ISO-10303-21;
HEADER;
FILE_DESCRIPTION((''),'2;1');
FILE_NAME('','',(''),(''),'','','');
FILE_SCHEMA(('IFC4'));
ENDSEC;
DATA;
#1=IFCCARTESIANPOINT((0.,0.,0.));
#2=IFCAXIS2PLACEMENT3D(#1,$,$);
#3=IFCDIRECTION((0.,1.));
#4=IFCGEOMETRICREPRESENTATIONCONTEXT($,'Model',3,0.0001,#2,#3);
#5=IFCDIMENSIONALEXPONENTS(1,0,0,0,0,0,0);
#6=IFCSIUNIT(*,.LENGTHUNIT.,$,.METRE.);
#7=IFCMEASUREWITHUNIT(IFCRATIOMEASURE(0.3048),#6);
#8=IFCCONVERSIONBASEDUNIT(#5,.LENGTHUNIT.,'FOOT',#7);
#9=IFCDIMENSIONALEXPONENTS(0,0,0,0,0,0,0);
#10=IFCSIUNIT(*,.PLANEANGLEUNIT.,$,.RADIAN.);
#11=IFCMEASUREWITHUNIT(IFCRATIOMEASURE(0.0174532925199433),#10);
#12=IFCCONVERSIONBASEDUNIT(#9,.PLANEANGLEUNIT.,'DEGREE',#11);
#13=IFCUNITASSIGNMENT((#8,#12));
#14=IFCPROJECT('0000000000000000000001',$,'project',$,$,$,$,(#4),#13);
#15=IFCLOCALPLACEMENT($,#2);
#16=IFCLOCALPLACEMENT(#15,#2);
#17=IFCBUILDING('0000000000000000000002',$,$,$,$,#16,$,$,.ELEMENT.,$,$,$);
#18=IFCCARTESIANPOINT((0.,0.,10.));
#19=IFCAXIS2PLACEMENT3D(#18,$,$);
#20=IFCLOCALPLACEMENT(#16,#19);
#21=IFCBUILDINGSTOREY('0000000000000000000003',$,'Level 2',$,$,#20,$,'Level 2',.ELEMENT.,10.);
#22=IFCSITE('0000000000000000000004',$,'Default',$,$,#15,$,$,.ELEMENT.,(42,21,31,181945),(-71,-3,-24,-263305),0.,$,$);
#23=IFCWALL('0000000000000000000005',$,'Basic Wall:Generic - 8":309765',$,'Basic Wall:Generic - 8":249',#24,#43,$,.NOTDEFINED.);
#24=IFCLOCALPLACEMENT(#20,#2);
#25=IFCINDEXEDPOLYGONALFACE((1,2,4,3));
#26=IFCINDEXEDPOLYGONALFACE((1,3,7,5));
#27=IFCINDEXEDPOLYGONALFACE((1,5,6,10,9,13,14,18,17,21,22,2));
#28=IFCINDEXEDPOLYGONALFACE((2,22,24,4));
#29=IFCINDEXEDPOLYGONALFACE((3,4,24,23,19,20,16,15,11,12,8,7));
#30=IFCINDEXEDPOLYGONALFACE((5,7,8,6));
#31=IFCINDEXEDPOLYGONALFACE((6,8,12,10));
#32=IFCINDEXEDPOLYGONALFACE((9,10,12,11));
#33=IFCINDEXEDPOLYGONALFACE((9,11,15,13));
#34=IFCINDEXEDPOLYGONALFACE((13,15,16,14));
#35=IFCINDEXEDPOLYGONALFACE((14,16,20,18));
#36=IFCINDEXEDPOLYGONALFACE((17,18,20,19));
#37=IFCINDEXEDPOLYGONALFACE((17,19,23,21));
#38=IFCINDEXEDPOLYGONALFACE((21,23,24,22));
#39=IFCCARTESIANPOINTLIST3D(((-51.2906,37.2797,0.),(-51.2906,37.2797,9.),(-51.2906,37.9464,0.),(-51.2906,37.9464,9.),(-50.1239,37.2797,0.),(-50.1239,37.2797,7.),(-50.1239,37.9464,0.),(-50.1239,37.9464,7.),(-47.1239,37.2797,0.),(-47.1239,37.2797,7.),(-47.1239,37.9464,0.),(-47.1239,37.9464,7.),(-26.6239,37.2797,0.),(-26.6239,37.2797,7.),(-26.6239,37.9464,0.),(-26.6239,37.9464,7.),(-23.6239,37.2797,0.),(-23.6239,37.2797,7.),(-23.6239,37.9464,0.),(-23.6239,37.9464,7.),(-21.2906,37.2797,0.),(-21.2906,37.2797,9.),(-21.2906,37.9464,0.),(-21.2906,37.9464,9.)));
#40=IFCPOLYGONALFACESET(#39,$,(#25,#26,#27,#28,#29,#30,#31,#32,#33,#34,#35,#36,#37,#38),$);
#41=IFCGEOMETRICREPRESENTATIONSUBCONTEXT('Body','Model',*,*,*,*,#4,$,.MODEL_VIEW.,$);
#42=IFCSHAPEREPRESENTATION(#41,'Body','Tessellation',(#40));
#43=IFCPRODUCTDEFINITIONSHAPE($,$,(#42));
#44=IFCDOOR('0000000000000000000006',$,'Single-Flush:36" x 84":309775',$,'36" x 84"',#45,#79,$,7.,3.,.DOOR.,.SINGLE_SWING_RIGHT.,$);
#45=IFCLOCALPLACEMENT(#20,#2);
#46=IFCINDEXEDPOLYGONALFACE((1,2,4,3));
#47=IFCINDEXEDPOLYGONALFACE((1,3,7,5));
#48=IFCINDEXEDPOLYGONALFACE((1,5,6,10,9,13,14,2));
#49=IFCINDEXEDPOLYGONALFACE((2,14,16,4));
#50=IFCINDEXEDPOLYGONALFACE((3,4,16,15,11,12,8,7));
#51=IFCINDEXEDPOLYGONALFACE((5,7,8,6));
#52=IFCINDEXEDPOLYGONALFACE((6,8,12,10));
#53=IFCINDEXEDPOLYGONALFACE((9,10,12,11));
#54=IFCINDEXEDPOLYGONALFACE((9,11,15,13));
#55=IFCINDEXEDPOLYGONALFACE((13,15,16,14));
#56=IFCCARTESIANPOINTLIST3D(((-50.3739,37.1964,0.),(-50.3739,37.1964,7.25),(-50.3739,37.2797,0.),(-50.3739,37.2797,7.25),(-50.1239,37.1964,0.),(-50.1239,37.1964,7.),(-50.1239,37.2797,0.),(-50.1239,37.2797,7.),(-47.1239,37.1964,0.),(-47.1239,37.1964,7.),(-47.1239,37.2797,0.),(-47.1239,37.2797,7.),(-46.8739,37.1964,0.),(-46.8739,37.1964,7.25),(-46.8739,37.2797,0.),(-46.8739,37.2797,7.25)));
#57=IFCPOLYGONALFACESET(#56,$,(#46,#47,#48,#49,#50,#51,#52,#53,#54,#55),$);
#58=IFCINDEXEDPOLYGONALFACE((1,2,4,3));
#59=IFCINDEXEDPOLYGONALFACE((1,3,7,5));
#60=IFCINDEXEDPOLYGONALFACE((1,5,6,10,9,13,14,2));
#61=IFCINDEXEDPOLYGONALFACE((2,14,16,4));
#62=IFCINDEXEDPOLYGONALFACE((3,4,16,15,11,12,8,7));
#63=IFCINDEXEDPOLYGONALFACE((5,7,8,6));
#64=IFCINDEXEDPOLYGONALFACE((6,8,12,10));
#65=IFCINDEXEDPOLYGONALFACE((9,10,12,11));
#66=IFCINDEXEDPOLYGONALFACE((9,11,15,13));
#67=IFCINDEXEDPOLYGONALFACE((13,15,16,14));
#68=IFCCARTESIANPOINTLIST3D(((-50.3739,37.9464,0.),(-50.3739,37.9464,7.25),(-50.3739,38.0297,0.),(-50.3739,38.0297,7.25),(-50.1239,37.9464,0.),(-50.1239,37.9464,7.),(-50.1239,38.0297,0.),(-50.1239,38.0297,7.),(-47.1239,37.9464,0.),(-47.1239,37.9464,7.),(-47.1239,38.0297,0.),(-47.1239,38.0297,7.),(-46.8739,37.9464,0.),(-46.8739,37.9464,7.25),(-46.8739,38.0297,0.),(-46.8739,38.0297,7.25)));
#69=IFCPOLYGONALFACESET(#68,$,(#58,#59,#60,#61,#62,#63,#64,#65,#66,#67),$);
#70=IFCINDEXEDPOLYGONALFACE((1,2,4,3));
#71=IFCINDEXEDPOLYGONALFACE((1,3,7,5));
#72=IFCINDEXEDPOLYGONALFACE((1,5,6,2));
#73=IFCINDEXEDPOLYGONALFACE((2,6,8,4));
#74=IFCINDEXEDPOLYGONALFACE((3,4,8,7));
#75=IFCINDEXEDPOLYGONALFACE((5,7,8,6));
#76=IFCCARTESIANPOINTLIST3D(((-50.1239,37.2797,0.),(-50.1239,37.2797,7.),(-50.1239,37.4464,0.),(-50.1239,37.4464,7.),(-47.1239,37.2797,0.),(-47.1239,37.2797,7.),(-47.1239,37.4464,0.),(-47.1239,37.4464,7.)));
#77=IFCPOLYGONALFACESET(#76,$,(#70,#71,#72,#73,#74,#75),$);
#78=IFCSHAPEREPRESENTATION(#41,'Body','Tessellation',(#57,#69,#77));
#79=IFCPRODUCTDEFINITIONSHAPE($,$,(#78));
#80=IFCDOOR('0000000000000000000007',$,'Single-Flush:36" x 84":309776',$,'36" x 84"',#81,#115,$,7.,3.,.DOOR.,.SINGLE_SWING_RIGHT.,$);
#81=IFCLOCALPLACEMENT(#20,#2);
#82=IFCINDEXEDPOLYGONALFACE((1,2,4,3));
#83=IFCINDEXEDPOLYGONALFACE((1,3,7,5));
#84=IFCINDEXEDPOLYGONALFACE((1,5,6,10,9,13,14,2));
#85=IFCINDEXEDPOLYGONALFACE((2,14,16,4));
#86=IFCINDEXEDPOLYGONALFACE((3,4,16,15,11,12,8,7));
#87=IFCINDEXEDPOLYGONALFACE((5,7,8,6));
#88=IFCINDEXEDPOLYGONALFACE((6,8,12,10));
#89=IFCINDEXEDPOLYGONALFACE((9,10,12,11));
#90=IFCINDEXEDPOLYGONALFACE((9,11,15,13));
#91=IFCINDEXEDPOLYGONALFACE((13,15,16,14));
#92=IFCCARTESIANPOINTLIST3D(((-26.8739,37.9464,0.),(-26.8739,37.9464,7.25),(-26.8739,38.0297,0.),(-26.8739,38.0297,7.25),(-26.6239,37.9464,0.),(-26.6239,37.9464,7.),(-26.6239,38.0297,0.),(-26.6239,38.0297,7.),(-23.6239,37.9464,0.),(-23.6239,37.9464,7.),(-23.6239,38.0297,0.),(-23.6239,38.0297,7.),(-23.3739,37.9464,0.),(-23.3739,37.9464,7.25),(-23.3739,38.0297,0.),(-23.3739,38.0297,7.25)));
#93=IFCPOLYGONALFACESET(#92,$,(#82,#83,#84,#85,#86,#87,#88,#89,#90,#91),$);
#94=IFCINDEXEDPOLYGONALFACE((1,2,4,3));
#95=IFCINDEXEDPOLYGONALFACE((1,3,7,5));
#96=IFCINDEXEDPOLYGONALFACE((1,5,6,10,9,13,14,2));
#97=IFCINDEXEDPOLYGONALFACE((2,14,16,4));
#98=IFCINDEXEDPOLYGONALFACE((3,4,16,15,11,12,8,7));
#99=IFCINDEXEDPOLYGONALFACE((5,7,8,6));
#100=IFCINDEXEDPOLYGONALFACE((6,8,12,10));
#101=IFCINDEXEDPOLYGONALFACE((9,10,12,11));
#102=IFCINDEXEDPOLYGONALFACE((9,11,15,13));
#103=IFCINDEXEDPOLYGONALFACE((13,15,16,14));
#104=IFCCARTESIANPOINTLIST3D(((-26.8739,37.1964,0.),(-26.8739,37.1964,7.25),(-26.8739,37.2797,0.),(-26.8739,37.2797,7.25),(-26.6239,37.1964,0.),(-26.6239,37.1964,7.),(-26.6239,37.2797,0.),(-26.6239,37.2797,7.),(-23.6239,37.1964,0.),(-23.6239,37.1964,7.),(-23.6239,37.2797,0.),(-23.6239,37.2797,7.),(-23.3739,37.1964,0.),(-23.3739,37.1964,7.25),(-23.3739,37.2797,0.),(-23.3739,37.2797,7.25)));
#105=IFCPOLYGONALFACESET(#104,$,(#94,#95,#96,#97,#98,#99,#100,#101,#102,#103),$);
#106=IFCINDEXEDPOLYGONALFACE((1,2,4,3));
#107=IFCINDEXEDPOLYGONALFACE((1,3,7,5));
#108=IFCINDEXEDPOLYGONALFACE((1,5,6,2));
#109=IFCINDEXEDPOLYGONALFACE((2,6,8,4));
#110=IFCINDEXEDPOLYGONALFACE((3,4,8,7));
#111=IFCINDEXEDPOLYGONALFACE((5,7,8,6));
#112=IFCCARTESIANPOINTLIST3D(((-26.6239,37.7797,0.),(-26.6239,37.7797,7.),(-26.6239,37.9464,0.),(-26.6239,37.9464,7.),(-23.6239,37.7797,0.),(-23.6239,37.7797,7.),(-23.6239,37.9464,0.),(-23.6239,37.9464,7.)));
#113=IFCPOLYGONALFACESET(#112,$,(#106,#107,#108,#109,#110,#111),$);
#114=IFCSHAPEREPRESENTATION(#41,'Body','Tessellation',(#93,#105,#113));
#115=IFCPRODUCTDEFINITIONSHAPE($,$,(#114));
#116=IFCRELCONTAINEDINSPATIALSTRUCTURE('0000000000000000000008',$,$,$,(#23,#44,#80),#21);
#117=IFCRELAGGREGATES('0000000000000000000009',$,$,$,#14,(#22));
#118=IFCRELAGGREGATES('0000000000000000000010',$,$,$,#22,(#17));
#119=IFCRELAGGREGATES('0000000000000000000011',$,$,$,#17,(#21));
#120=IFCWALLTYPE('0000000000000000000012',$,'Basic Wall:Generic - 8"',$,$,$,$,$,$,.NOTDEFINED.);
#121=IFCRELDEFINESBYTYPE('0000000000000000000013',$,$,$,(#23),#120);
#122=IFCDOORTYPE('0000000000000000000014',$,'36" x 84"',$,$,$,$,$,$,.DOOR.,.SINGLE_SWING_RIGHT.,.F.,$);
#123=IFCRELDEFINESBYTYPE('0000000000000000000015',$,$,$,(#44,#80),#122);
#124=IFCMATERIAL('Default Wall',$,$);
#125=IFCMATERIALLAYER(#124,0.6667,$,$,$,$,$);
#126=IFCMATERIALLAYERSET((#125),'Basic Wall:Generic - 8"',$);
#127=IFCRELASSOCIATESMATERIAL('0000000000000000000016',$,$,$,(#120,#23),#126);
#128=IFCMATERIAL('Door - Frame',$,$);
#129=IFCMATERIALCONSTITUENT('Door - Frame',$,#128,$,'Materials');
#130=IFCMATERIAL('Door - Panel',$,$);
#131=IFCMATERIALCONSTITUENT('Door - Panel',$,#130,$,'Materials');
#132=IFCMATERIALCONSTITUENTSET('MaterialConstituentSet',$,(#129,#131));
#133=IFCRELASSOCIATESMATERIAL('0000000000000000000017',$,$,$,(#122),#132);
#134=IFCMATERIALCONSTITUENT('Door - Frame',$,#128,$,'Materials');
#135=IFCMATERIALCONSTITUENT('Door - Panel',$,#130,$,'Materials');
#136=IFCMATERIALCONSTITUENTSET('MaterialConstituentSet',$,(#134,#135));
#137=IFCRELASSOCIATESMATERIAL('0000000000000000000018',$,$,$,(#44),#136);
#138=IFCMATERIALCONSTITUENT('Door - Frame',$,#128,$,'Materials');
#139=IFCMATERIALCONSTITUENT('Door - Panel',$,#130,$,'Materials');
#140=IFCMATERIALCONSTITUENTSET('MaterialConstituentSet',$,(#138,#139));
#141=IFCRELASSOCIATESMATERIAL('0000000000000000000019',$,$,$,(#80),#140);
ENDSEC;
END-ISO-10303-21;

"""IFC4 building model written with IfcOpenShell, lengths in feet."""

from ifc_helpers import new_model, entity, si_unit, converted_unit, direction, frame, frame_2d, origin, place, context, subcontext, project, spatial, polyline, rectangle, outline, extrude, clip, bounded_halfspace, source, transform, mapped, material, layer, layer_set, layer_usage, constituent, constituent_set, type_object, type_shapes, element, fill, save


model = new_model("IFC4")

# Units and contexts
model_context = context("Model", 3, precision=0.0001, world=origin(), true_north=direction((0.0, 1.0)))
body_context = subcontext(model_context, "Body", "Model", "MODEL_VIEW")
ifc_project = project(units=[converted_unit("LENGTHUNIT", "FOOT", entity("IfcRatioMeasure", 0.3048), si_unit("LENGTHUNIT", "METRE"), dimensions=[1, 0, 0, 0, 0, 0, 0]), converted_unit("PLANEANGLEUNIT", "DEGREE", entity("IfcRatioMeasure", 0.0174532925199433), si_unit("PLANEANGLEUNIT", "RADIAN"), dimensions=[0, 0, 0, 0, 0, 0, 0])], contexts=[model_context])

# Site, building, storey
site_placement = place(None, origin())
site = spatial("IfcSite", under=ifc_project, at=site_placement, Name="Default", CompositionType="ELEMENT", RefLatitude=(42, 21, 31, 181945), RefLongitude=(-71, -3, -24, -263305), RefElevation=0.0)
building_placement = place(site_placement, origin())
building = spatial("IfcBuilding", under=site, at=building_placement, CompositionType="ELEMENT")
storey_placement = place(building_placement, frame((0.0, 0.0, 10.0)))
storey = spatial("IfcBuildingStorey", under=building, at=storey_placement, Name="Level 2", LongName="Level 2", CompositionType="ELEMENT", Elevation=10.0)

# Wall, openings, doors
ifc_material_1 = material(Name="Default Wall")
ifc_layer_1 = layer(ifc_material_1, 0.6667)
ifc_layer_set_1 = layer_set([ifc_layer_1], Name="Basic Wall:Generic - 8\"")
ifc_layer_usage_1 = layer_usage(ifc_layer_set_1, "AXIS2", "NEGATIVE", 0.3333)
wall_type = type_object("IfcWallType", Name="Basic Wall:Generic - 8\"", PredefinedType="NOTDEFINED", material=ifc_layer_set_1)
wall_1_placement = place(storey_placement, frame((-21.2906, 37.6131, 0.0), z_axis=(0.0, 0.0, 1.0), x_axis=(-1.0, 0.0, 0.0)))
wall_1 = element("IfcWall", 1, at=wall_1_placement, inside=storey, type_object=wall_type, material=ifc_layer_usage_1, Name="Basic Wall:Generic - 8\":309765", ObjectType="Basic Wall:Generic - 8\":249", PredefinedType="NOTDEFINED", context=body_context, shape_type="Clipping", body=[
    clip(extrude(rectangle(XDim=30.0, YDim=0.6667, at=frame_2d((15.0, 0.0), x_axis=(-1.0, 0.0))), origin(), (0.0, 0.0, 1.0), 9.0), bounded_halfspace(frame((0.0, -0.3333, 9.0), z_axis=(0.0, 0.0, -1.0), x_axis=(-1.0, 0.0, 0.0)), True, frame((0.0, -0.3333, 9.0)), polyline([(0.0, 0.0), (30.0, 0.0), (30.0, 0.6667), (0.6667, 0.6667), (0.0, 0.6667), (0.0, 0.0)]))),
])
opening_1_placement = place(wall_1_placement, frame((25.8333, -0.3333, 0.0)))
opening_1 = element("IfcOpeningElement", 2, at=opening_1_placement, cuts=wall_1, ObjectType="Opening", PredefinedType="OPENING", context=body_context, shape_type="SweptSolid", body=[
    extrude(rectangle(XDim=3.0, YDim=7.0, at=frame_2d((3.5, 1.5), x_axis=(0.0, 1.0))), frame((0.0, 0.0, 0.0), z_axis=(0.0, 1.0, 0.0), x_axis=(0.0, 0.0, 1.0)), (0.0, 0.0, 1.0), 0.6667),
])
opening_2_placement = place(wall_1_placement, frame((5.3333, 0.3333, 0.0)))
opening_2 = element("IfcOpeningElement", 3, at=opening_2_placement, cuts=wall_1, ObjectType="Opening", PredefinedType="OPENING", context=body_context, shape_type="SweptSolid", body=[
    extrude(rectangle(XDim=3.0, YDim=7.0, at=frame_2d((3.5, 1.5), x_axis=(0.0, 1.0))), frame((0.0, 0.0, 0.0), z_axis=(0.0, -1.0, 0.0), x_axis=(0.0, 0.0, 1.0)), (0.0, 0.0, 1.0), 0.6667),
])
ifc_material_2 = material(Name="Door - Frame")
ifc_constituent_1 = constituent(ifc_material_2, Name="Door - Frame", Category="Materials")
ifc_material_3 = material(Name="Door - Panel")
ifc_constituent_2 = constituent(ifc_material_3, Name="Door - Panel", Category="Materials")
ifc_constituent_set_1 = constituent_set(constituents=[ifc_constituent_1, ifc_constituent_2], Name="MaterialConstituentSet")
ifc_constituent_3 = constituent(ifc_material_2, Name="Door - Frame", Category="Materials")
ifc_constituent_4 = constituent(ifc_material_3, Name="Door - Panel", Category="Materials")
ifc_constituent_set_2 = constituent_set(constituents=[ifc_constituent_3, ifc_constituent_4], Name="MaterialConstituentSet")
door_type = type_object("IfcDoorType", Name="36\" x 84\"", OperationType="SINGLE_SWING_RIGHT", ParameterTakesPrecedence=False, PredefinedType="DOOR", material=ifc_constituent_set_2)
shared_shape_1 = source(origin(), body_context, "Body", "SweptSolid", [
    extrude(outline(polyline([(-1.75, -3.6875), (1.75, -3.6875), (1.75, 3.5625), (1.5, 3.5625), (1.5, -3.4375), (-1.5, -3.4375), (-1.5, 3.5625), (-1.75, 3.5625), (-1.75, -3.6875)])), frame((1.5, 0.6667, 3.5625), z_axis=(0.0, 1.0, 0.0), x_axis=(1.0, 0.0, 0.0)), (0.0, 0.0, 1.0), 0.0833),
    extrude(outline(polyline([(-3.6875, -1.75), (3.5625, -1.75), (3.5625, -1.5), (-3.4375, -1.5), (-3.4375, 1.5), (3.5625, 1.5), (3.5625, 1.75), (-3.6875, 1.75), (-3.6875, -1.75)])), frame((1.5, -0.0833, 3.5625), z_axis=(0.0, 1.0, 0.0), x_axis=(0.0, 0.0, -1.0)), (0.0, 0.0, 1.0), 0.0833),
    extrude(rectangle(XDim=0.1667, YDim=3.0, at=frame_2d((0.0, 0.0), x_axis=(1.0, 0.0))), frame((1.5, 0.5833, 0.0), z_axis=(0.0, 0.0, 1.0), x_axis=(0.0, 1.0, 0.0)), (0.0, 0.0, 1.0), 7.0),
])
type_shapes(door_type, [shared_shape_1])
door_1_placement = place(opening_1_placement, origin())
door_1 = element("IfcDoor", 4, at=door_1_placement, inside=storey, type_object=door_type, material=ifc_constituent_set_1, Name="Single-Flush:36\" x 84\":309775", ObjectType="36\" x 84\"", OperationType="SINGLE_SWING_RIGHT", OverallHeight=7.0, OverallWidth=3.0, PredefinedType="DOOR", context=body_context, shape_type="MappedRepresentation", body=[
    mapped(shared_shape_1, transform((0.0, 0.0, 0.0), scale=1.0)),
])
fill(opening_1, door_1)
ifc_constituent_5 = constituent(ifc_material_2, Name="Door - Frame", Category="Materials")
ifc_constituent_6 = constituent(ifc_material_3, Name="Door - Panel", Category="Materials")
ifc_constituent_set_3 = constituent_set(constituents=[ifc_constituent_5, ifc_constituent_6], Name="MaterialConstituentSet")
door_2_placement = place(opening_2_placement, frame((0.0, 0.0, 0.0), z_axis=(0.0, 0.0, 1.0), x_axis=(-1.0, 0.0, 0.0)))
door_2 = element("IfcDoor", 5, at=door_2_placement, inside=storey, type_object=door_type, material=ifc_constituent_set_3, Name="Single-Flush:36\" x 84\":309776", ObjectType="36\" x 84\"", OperationType="SINGLE_SWING_RIGHT", OverallHeight=7.0, OverallWidth=3.0, PredefinedType="DOOR", context=body_context, shape_type="MappedRepresentation", body=[
    mapped(shared_shape_1, transform((0.0, 0.0, 0.0), scale=1.0)),
])
fill(opening_2, door_2)

save(model, "model.ifc")
